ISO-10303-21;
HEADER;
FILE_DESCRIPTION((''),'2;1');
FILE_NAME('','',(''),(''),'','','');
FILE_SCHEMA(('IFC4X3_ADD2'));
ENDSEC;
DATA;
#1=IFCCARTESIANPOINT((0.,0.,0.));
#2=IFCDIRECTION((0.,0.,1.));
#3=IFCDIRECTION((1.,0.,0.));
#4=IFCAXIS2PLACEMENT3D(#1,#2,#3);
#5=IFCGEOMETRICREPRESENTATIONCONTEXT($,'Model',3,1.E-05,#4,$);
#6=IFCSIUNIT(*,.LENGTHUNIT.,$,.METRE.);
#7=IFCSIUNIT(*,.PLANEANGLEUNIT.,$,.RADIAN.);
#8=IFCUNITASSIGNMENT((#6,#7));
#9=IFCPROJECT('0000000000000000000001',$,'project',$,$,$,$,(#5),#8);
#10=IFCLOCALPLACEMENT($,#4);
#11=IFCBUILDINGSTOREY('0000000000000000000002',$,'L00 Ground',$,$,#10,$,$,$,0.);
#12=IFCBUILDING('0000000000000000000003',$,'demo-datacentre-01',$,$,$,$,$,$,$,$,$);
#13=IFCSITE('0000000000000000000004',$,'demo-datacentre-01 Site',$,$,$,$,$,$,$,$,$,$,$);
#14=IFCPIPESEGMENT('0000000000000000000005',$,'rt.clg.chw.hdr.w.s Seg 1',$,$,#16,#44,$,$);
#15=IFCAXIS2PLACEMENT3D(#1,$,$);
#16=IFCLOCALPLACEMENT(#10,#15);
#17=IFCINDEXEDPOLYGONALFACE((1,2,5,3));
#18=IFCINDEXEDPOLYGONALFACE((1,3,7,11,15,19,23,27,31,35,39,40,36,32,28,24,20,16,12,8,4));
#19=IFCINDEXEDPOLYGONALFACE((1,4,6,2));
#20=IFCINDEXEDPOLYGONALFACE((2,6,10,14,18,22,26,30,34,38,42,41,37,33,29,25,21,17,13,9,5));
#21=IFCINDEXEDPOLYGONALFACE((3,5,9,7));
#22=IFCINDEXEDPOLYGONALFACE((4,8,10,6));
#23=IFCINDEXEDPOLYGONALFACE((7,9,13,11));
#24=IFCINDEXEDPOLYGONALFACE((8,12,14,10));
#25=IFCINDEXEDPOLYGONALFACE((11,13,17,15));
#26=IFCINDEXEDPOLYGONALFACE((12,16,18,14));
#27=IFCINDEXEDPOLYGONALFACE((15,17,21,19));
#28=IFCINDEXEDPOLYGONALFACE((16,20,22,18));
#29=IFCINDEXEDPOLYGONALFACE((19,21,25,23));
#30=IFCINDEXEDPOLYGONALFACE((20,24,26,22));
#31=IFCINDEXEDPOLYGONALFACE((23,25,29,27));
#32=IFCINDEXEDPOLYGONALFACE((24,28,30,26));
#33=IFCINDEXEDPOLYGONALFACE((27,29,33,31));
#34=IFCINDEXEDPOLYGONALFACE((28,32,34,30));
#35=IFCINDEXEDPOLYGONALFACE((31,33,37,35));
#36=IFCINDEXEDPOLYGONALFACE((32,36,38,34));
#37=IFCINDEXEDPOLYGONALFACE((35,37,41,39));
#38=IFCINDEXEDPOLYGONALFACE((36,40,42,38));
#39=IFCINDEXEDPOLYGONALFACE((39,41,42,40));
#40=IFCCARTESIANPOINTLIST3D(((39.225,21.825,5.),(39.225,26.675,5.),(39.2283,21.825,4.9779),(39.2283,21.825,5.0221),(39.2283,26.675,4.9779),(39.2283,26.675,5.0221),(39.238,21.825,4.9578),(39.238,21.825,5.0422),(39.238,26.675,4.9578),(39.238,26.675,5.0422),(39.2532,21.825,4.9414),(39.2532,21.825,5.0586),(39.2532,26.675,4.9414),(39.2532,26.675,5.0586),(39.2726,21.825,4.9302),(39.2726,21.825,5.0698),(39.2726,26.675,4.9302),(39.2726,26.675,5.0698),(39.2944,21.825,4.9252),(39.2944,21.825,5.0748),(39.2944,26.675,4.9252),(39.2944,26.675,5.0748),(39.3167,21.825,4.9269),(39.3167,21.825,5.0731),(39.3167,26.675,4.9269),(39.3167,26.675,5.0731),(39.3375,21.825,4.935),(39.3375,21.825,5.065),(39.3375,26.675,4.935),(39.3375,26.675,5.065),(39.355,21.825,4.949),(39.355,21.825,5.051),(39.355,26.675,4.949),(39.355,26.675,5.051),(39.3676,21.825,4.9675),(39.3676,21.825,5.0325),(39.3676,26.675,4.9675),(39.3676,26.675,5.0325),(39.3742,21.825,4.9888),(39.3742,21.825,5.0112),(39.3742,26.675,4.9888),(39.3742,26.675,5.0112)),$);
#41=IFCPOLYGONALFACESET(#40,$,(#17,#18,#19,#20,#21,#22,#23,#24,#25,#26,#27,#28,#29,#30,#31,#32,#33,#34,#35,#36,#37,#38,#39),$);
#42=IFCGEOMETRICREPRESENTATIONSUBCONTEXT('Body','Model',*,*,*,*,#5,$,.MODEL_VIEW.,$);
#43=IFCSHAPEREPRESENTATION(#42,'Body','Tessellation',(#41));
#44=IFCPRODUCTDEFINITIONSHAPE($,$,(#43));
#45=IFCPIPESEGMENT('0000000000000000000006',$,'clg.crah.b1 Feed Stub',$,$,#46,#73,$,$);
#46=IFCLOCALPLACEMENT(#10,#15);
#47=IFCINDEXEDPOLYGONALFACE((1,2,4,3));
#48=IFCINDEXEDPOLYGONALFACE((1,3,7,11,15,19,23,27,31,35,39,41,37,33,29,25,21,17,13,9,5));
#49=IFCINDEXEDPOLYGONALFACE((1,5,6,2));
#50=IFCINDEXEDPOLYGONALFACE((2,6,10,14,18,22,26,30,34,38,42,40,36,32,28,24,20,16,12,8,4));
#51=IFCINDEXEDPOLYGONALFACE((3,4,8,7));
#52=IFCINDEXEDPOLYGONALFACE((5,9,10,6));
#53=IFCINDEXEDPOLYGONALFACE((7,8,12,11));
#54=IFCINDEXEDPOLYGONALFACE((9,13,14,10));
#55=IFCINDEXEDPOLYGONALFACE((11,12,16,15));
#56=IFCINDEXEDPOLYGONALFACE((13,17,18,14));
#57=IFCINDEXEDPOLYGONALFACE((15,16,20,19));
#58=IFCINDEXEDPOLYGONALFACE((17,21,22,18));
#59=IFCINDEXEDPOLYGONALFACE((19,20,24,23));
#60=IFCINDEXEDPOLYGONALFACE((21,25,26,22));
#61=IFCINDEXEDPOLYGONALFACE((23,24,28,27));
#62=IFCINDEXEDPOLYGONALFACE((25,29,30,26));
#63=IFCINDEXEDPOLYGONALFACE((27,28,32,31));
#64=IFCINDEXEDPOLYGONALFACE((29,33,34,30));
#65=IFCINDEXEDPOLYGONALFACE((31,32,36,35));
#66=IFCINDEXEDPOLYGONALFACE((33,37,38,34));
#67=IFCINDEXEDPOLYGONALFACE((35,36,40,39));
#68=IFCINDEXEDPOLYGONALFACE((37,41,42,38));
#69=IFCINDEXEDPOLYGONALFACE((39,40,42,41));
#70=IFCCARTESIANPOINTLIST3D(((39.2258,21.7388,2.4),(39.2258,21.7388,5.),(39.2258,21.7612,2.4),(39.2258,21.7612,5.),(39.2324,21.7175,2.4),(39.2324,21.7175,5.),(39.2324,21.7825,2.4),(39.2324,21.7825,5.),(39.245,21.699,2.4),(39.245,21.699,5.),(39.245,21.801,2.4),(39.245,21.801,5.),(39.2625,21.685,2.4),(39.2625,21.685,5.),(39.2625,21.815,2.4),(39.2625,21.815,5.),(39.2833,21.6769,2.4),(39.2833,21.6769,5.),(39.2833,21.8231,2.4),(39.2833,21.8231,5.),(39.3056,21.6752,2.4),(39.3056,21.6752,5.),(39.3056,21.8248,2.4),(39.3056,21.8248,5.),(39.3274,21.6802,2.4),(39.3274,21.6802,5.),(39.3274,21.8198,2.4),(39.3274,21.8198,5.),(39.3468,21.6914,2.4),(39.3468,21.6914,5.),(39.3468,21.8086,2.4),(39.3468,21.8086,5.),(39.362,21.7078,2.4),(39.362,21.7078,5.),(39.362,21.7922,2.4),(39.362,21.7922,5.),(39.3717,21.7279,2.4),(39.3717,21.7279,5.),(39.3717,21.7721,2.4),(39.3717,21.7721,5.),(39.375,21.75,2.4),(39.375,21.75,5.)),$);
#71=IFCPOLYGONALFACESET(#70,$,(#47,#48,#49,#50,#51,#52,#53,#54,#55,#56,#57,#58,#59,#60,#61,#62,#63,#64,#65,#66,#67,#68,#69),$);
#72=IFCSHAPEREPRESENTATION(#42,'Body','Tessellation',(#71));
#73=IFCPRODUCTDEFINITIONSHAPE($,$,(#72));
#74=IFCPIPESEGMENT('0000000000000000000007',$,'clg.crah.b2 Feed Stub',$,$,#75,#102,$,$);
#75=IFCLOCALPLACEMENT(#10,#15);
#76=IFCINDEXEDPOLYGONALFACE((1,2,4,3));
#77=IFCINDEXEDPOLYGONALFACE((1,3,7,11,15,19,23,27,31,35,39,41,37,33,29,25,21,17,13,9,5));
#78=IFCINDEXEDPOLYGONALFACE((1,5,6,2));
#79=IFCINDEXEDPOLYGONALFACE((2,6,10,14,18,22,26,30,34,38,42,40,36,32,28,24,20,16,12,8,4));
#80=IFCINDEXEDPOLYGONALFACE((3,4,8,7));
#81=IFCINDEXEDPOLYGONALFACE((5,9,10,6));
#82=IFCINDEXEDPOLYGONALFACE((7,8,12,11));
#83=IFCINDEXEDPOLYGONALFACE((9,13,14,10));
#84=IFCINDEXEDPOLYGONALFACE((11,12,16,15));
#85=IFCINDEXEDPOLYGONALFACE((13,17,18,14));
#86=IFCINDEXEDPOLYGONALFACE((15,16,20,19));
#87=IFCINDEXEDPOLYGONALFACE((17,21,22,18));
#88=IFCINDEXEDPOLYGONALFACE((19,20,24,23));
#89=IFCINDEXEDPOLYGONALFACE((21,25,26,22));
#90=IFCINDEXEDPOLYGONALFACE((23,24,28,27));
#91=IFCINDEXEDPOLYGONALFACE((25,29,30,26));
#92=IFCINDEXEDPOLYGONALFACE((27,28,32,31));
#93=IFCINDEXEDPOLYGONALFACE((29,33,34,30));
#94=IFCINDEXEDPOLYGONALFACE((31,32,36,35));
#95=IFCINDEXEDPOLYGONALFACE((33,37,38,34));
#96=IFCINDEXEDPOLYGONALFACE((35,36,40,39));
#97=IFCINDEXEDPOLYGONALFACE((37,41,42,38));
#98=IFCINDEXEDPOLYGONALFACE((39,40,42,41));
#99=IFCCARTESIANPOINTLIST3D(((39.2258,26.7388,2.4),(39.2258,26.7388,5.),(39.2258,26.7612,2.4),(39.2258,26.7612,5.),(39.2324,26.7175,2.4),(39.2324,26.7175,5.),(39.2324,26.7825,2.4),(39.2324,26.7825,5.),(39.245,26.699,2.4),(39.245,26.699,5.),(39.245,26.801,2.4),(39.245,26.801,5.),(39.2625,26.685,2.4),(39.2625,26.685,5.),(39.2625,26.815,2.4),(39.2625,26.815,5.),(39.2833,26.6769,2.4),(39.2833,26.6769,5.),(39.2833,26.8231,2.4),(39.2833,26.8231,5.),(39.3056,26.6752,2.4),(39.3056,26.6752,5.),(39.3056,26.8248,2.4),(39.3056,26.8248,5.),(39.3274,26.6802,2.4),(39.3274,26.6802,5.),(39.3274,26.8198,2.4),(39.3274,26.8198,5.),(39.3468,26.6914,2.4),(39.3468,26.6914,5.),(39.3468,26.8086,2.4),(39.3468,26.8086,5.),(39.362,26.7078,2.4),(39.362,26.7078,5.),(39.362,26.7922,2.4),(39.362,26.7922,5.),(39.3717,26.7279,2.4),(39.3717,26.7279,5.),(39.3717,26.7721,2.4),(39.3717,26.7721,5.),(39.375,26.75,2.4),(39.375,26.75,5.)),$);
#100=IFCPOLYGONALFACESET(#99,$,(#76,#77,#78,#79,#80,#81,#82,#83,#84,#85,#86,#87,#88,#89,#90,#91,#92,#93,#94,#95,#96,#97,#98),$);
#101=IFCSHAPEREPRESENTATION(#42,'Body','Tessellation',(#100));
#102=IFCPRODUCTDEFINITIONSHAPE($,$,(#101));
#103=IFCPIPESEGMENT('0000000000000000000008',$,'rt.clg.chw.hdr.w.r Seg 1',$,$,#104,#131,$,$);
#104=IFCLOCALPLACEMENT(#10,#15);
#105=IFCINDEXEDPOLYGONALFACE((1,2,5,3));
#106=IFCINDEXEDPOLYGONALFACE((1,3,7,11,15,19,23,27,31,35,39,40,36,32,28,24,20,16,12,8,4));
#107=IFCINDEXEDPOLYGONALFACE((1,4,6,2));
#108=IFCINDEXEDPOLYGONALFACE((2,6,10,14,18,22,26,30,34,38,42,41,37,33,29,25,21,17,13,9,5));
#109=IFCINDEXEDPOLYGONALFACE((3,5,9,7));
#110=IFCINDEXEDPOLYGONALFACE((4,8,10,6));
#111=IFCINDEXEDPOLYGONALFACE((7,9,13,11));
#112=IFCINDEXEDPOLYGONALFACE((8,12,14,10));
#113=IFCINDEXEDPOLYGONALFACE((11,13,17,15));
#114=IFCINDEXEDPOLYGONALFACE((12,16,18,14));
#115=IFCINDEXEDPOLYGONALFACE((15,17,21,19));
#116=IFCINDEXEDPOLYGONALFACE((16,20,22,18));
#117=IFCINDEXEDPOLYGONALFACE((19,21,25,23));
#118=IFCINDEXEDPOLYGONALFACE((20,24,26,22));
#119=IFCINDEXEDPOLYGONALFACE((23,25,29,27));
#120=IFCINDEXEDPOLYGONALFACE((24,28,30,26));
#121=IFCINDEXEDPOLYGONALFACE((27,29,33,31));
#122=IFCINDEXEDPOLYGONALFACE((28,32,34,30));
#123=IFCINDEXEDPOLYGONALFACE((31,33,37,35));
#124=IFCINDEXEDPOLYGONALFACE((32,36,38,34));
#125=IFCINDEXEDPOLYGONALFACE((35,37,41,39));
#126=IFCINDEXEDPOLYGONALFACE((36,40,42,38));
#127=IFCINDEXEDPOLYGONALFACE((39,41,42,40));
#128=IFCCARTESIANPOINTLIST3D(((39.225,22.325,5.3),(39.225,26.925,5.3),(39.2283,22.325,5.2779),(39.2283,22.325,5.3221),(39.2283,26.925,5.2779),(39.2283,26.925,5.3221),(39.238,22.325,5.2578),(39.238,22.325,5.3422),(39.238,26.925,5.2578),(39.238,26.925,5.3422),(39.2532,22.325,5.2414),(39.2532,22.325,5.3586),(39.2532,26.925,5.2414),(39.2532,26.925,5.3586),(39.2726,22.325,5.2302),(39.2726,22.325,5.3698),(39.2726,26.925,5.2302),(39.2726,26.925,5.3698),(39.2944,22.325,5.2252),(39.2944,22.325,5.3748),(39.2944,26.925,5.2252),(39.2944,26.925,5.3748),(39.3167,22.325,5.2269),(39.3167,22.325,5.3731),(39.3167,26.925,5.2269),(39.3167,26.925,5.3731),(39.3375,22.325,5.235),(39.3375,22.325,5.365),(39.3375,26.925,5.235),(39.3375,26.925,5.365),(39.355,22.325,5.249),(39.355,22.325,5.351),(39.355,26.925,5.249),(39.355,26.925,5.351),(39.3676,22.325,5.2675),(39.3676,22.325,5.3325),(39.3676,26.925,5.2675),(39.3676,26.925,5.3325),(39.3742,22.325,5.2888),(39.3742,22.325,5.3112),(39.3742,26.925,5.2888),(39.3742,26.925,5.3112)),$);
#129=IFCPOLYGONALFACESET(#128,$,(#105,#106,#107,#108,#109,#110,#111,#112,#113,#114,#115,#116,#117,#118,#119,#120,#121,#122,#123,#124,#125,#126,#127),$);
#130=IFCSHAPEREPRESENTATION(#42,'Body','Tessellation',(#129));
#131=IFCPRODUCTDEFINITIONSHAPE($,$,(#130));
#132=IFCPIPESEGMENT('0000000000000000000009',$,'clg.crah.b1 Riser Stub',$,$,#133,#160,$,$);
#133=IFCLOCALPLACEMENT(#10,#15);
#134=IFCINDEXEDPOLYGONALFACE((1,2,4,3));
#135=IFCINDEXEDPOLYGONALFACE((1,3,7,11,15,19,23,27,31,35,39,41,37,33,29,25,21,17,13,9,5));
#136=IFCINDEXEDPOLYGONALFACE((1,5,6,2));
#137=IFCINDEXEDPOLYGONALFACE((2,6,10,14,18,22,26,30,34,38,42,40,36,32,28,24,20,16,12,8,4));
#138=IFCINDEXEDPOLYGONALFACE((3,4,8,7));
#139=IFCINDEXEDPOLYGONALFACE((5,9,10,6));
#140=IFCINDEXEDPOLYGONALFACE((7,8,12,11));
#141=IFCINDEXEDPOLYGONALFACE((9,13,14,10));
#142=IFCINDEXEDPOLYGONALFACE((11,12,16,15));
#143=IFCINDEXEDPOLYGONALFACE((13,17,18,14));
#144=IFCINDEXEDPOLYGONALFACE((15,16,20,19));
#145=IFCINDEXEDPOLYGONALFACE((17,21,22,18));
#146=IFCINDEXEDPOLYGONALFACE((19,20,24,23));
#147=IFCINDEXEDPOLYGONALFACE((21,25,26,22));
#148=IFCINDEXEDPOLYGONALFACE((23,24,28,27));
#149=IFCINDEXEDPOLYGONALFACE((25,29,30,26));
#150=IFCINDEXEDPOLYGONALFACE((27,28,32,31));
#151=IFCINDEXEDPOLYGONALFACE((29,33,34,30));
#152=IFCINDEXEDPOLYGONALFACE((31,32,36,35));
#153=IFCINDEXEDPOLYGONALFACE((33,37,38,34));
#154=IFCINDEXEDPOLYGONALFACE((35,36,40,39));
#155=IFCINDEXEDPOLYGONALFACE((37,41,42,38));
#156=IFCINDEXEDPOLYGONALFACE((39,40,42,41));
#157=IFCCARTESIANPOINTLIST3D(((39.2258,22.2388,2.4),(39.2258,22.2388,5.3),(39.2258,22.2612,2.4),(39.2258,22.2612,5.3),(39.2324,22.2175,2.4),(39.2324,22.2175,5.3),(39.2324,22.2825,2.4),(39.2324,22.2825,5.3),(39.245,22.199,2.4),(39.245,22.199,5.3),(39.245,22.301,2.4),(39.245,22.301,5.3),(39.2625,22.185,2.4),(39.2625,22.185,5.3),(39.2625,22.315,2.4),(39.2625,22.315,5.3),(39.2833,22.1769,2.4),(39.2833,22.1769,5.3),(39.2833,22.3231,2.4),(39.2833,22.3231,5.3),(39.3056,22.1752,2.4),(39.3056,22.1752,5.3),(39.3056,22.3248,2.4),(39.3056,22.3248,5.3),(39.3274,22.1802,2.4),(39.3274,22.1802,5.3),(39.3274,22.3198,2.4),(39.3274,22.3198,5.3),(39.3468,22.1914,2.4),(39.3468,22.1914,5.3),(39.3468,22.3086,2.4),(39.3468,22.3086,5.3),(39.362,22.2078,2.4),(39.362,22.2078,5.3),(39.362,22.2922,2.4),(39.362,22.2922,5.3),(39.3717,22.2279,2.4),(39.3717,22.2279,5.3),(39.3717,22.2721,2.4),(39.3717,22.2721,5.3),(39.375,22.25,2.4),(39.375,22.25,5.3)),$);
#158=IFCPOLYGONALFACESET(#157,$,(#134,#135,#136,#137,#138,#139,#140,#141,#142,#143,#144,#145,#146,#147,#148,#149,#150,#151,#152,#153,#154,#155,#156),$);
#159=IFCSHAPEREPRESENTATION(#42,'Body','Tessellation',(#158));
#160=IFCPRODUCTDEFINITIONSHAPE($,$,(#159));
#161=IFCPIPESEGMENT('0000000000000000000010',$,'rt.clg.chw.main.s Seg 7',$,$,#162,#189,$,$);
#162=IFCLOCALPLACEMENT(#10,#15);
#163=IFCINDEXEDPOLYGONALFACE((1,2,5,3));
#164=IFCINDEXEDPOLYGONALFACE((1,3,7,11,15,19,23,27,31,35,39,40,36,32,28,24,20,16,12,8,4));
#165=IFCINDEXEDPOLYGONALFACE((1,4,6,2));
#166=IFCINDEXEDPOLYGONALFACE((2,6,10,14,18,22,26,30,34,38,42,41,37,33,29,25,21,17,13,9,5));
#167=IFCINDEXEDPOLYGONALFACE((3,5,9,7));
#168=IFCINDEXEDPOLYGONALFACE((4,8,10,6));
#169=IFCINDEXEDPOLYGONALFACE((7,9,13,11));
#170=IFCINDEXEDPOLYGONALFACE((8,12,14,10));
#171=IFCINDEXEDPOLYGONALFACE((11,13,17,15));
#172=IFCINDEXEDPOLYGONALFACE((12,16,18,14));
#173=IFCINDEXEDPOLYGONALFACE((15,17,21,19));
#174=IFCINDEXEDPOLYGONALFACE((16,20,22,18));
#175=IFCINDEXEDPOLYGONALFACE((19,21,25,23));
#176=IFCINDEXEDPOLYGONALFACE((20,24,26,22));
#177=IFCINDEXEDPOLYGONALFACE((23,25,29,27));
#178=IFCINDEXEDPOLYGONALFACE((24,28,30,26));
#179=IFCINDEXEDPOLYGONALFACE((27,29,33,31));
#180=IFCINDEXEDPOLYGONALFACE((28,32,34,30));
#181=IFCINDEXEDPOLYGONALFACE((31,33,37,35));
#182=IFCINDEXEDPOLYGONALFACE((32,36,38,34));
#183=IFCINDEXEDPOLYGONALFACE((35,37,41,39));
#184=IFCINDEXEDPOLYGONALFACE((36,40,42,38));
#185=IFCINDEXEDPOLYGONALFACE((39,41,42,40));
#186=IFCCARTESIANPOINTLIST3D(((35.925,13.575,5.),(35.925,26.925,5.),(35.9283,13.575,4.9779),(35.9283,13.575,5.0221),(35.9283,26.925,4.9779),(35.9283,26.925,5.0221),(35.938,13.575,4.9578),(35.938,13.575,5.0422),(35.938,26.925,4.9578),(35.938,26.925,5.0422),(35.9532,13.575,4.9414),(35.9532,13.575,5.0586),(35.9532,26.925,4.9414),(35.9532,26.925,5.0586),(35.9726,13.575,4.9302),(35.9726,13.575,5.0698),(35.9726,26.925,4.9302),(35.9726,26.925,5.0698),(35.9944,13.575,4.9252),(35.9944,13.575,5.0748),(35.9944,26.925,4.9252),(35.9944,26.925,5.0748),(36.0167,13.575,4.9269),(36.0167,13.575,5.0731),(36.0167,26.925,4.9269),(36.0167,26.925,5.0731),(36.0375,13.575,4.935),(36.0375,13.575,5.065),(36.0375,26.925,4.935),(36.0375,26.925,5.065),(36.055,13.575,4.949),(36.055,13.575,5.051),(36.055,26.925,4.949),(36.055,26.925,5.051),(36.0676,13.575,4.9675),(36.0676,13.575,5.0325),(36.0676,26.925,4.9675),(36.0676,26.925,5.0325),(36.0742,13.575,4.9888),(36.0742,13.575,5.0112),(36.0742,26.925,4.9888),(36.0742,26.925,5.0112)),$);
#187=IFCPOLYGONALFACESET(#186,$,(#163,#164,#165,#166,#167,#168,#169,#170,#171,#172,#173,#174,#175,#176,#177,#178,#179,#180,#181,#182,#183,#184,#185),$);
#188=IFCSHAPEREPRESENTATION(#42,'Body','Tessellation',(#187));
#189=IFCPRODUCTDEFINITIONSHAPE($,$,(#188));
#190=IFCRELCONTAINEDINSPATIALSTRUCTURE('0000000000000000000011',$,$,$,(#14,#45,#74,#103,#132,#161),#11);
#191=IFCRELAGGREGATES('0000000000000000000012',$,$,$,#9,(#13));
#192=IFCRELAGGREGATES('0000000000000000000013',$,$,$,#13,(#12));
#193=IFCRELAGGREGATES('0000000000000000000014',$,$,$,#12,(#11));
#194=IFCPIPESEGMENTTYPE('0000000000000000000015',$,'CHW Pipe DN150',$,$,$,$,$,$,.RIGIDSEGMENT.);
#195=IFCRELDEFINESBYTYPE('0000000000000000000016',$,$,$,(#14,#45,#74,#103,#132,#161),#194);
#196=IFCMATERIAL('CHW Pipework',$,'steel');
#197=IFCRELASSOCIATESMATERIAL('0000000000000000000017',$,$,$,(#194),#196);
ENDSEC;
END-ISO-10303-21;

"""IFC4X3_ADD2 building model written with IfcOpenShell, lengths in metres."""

from ifc_helpers import new_model, si_unit, frame, origin_with_axes, place, context, subcontext, project, spatial, circle, extrude, material, type_object, element, save


model = new_model("IFC4X3_ADD2")

# Units and contexts
model_context = context("Model", 3, precision=1e-05, world=origin_with_axes())
body_context = subcontext(model_context, "Body", "Model", "MODEL_VIEW")
ifc_project = project(units=[si_unit("LENGTHUNIT", "METRE"), si_unit("PLANEANGLEUNIT", "RADIAN")], contexts=[model_context])

# Site, building, storey
site = spatial("IfcSite", under=ifc_project, Name="demo-datacentre-01 Site")
building = spatial("IfcBuilding", under=site, Name="demo-datacentre-01")
storey_placement = place(None, origin_with_axes())
storey = spatial("IfcBuildingStorey", under=building, at=storey_placement, Name="L00 Ground", Elevation=0.0)

# Shared definitions
ifc_material_1 = material(Name="CHW Pipework", Category="steel")

# Pipe segments
pipe_segment_type_1 = type_object("IfcPipeSegmentType", Name="CHW Pipe DN150", PredefinedType="RIGIDSEGMENT", material=ifc_material_1)
pipe_segment_1_placement = place(storey_placement, frame((39.3, 21.825, 5.0), z_axis=(0.0, 1.0, 0.0), x_axis=(-1.0, 0.0, 0.0)))
element("IfcPipeSegment", 1, at=pipe_segment_1_placement, inside=storey, type_object=pipe_segment_type_1, Name="rt.clg.chw.hdr.w.s Seg 1", context=body_context, shape_type="SweptSolid", body=[
    extrude(circle(Radius=0.075), origin_with_axes(), (0.0, 0.0, 1.0), 4.85),
])
for number, where, z_axis, x_axis, name in (
    (2, (39.3, 21.75, 5.0), (0.0, 0.0, -1.0), (1.0, 0.0, 0.0), "clg.crah.b1 Feed Stub"),
    (3, (39.3, 26.75, 5.0), (0.0, 0.0, -1.0), (1.0, 0.0, 0.0), "clg.crah.b2 Feed Stub"),
):
    element("IfcPipeSegment", number, at=place(storey_placement, frame(where, z_axis=z_axis, x_axis=x_axis)), inside=storey, type_object=pipe_segment_type_1, Name=name, context=body_context, shape_type="SweptSolid", body=[
        extrude(circle(Radius=0.075), origin_with_axes(), (0.0, 0.0, 1.0), 2.6),
    ])
pipe_segment_2_placement = place(storey_placement, frame((39.3, 22.325, 5.3), z_axis=(0.0, 1.0, 0.0), x_axis=(-1.0, 0.0, 0.0)))
element("IfcPipeSegment", 4, at=pipe_segment_2_placement, inside=storey, type_object=pipe_segment_type_1, Name="rt.clg.chw.hdr.w.r Seg 1", context=body_context, shape_type="SweptSolid", body=[
    extrude(circle(Radius=0.075), origin_with_axes(), (0.0, 0.0, 1.0), 4.6),
])
pipe_segment_3_placement = place(storey_placement, frame((39.3, 22.25, 5.3), z_axis=(0.0, 0.0, -1.0), x_axis=(1.0, 0.0, 0.0)))
element("IfcPipeSegment", 5, at=pipe_segment_3_placement, inside=storey, type_object=pipe_segment_type_1, Name="clg.crah.b1 Riser Stub", context=body_context, shape_type="SweptSolid", body=[
    extrude(circle(Radius=0.075), origin_with_axes(), (0.0, 0.0, 1.0), 2.9),
])
pipe_segment_4_placement = place(storey_placement, frame((36.0, 13.575, 5.0), z_axis=(0.0, 1.0, 0.0), x_axis=(-1.0, 0.0, 0.0)))
element("IfcPipeSegment", 6, at=pipe_segment_4_placement, inside=storey, type_object=pipe_segment_type_1, Name="rt.clg.chw.main.s Seg 7", context=body_context, shape_type="SweptSolid", body=[
    extrude(circle(Radius=0.075), origin_with_axes(), (0.0, 0.0, 1.0), 13.35),
])

save(model, "model.ifc")
